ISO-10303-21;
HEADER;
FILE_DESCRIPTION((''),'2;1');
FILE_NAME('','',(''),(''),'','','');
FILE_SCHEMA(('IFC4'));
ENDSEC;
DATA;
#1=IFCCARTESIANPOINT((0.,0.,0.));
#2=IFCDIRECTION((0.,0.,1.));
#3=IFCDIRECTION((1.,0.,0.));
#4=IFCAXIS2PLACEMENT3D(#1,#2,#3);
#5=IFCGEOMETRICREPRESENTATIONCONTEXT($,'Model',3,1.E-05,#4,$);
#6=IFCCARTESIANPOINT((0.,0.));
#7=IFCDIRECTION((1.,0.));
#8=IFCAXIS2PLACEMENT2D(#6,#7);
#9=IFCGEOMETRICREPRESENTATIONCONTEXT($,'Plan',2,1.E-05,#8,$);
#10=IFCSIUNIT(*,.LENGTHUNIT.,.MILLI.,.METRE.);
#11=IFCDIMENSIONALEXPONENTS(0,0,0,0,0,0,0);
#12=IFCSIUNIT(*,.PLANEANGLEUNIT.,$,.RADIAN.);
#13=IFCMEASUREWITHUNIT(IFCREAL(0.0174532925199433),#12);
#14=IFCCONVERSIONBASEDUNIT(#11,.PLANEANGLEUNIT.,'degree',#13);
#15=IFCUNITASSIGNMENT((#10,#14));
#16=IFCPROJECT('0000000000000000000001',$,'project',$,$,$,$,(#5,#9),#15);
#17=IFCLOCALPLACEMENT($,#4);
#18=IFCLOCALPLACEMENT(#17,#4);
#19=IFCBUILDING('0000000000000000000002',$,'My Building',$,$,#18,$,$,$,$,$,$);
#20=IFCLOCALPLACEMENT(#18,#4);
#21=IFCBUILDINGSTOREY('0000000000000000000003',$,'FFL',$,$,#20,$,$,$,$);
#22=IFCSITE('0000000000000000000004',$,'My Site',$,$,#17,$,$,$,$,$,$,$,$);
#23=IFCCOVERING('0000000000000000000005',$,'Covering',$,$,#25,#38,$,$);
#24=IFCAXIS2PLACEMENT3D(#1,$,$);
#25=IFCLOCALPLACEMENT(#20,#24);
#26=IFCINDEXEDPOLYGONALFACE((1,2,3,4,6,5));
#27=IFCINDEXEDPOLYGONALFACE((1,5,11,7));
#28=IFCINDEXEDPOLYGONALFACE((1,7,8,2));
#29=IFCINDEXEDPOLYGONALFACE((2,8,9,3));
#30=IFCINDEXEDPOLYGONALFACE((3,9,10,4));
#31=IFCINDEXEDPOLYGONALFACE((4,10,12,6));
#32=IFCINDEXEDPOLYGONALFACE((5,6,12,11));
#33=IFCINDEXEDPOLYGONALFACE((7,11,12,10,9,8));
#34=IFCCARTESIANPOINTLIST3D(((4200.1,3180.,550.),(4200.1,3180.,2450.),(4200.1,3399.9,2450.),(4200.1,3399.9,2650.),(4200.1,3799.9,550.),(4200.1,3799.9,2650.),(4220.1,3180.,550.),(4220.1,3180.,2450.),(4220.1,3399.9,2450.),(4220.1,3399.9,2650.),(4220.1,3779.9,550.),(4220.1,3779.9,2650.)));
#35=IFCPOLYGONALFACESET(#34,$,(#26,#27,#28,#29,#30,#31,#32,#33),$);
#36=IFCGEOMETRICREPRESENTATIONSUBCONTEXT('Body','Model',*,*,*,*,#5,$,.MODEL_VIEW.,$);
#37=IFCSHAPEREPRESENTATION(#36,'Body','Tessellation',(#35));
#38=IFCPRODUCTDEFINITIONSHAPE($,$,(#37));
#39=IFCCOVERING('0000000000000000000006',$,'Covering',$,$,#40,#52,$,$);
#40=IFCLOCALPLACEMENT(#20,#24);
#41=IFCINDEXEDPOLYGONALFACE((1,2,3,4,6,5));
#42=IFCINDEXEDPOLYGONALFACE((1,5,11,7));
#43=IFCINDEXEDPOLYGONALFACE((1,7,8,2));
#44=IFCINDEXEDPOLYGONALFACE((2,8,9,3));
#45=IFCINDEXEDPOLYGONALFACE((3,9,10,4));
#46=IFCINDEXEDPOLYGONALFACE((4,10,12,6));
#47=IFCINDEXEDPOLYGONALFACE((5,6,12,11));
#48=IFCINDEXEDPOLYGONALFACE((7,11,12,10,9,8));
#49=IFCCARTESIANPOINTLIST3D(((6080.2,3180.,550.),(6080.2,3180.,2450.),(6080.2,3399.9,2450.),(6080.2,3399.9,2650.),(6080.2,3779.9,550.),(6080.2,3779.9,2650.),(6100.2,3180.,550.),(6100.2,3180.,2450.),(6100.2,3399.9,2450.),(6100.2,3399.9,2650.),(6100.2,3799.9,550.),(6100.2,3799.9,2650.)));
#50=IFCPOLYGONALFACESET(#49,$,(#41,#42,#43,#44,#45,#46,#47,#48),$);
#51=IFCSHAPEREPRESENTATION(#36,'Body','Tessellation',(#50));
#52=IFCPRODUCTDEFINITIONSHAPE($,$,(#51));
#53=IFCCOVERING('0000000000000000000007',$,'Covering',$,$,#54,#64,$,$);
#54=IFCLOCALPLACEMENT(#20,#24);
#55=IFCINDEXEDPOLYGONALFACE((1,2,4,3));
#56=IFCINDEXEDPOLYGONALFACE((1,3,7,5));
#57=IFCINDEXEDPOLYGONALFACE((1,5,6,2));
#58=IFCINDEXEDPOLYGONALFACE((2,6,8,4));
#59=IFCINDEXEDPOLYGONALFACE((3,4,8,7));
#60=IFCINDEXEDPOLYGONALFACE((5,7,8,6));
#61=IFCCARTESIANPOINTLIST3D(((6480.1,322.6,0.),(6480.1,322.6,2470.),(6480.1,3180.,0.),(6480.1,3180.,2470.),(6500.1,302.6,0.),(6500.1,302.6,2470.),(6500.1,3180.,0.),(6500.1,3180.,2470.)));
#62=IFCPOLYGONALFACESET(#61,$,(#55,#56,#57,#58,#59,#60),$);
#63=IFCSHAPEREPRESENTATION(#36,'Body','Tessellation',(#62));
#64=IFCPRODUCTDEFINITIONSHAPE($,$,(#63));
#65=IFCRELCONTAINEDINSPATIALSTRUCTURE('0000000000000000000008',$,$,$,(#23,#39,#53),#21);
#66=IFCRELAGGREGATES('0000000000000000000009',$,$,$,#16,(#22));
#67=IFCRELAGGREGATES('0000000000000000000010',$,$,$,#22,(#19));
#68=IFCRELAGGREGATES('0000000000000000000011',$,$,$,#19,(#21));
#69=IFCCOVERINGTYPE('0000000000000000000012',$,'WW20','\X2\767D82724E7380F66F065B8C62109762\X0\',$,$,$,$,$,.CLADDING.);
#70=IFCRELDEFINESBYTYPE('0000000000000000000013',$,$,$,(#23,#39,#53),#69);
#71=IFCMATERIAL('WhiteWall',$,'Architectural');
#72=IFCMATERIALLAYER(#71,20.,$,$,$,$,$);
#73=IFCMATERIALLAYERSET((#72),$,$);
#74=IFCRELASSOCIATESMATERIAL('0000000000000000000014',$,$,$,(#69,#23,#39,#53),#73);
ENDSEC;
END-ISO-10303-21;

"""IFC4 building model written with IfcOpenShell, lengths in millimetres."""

from ifc_helpers import new_model, entity, si_unit, converted_unit, frame, origin_with_axes, origin_2d_with_axis, place, context, subcontext, project, spatial, line, indexed_curve, outline, extrude, material, layer, layer_set, layer_usage, type_object, element, save


model = new_model("IFC4")

# Units and contexts
model_context = context("Model", 3, precision=1e-05, world=origin_with_axes())
plan_context = context("Plan", 2, precision=1e-05, world=origin_2d_with_axis())
body_context_1 = subcontext(model_context, "Body", "Model", "MODEL_VIEW")
ifc_project = project(units=[si_unit("LENGTHUNIT", "METRE", prefix="MILLI"), converted_unit("PLANEANGLEUNIT", "degree", entity("IfcReal", 0.0174532925199433), si_unit("PLANEANGLEUNIT", "RADIAN"), dimensions=[0, 0, 0, 0, 0, 0, 0])], contexts=[model_context, plan_context])

# Site, building, storey
site_placement = place(None, origin_with_axes())
site = spatial("IfcSite", under=ifc_project, at=site_placement, Name="My Site")
building_placement = place(site_placement, origin_with_axes())
building = spatial("IfcBuilding", under=site, at=building_placement, Name="My Building")
storey_placement = place(building_placement, origin_with_axes())
storey = spatial("IfcBuildingStorey", under=building, at=storey_placement, Name="FFL")

# Coverings, openings
ifc_material_1 = material(Name="WhiteWall", Category="Architectural")
ifc_layer_1 = layer(ifc_material_1, 20.0)
ifc_layer_set_1 = layer_set([ifc_layer_1])
ifc_layer_usage_1 = layer_usage(ifc_layer_set_1, "AXIS2", "POSITIVE", 0.0)
covering_type = type_object("IfcCoveringType", Name="WW20", Description="白色乳胶漆完成面", PredefinedType="CLADDING", material=ifc_layer_set_1)
covering_1_placement = place(storey_placement, frame((4200.1, 3799.9, 550.0), z_axis=(0.0, 0.0, 1.0), x_axis=(-0.000001, -1.0, 0.0)))
covering_1 = element("IfcCovering", 1, at=covering_1_placement, inside=storey, type_object=covering_type, material=ifc_layer_usage_1, Name="Covering", context=body_context_1, shape_type="SweptSolid", body=[
    extrude(outline(indexed_curve([(0.0, 0.0), (20.0, 20.0), (620.0, 20.0), (620.0, 0.0)], segments=[line(1, 2, 3, 4, 1)])), origin_with_axes(), (0.0, 0.0, 1.0), 2100.0),
])
opening_1_placement = place(covering_1_placement, frame((620.0, 120.0, 1900.0), z_axis=(0.000001, -1.0, 0.0), x_axis=(0.0, 0.0, 1.0)))
element("IfcOpeningElement", 2, at=opening_1_placement, cuts=covering_1, PredefinedType="OPENING", context=body_context_1, shape_type="SweptSolid", body=[
    extrude(outline(indexed_curve([(0.0, 220.0), (500.0, 220.0), (500.0, -100.0), (0.0, -100.0), (0.0, 220.0)])), origin_with_axes(), (0.0, 0.0, 1.0), 500.0),
])
ifc_layer_usage_2 = layer_usage(ifc_layer_set_1, "AXIS2", "NEGATIVE", 0.0)
covering_2_placement = place(storey_placement, frame((6100.2, 3799.9, 550.0), z_axis=(0.0, 0.0, 1.0), x_axis=(-0.000001, -1.0, 0.0)))
covering_2 = element("IfcCovering", 3, at=covering_2_placement, inside=storey, type_object=covering_type, material=ifc_layer_usage_2, Name="Covering", context=body_context_1, shape_type="SweptSolid", body=[
    extrude(outline(indexed_curve([(20.0, -20.0), (0.0, 0.0), (620.0, 0.0), (620.0, -20.0)], segments=[line(1, 2, 3, 4, 1)])), origin_with_axes(), (0.0, 0.0, 1.0), 2100.0),
])
opening_2_placement = place(covering_2_placement, frame((620.0, 120.0, 1900.0), z_axis=(0.000001, -1.0, 0.0), x_axis=(0.0, 0.0, 1.0)))
element("IfcOpeningElement", 4, at=opening_2_placement, cuts=covering_2, PredefinedType="OPENING", context=body_context_1, shape_type="SweptSolid", body=[
    extrude(outline(indexed_curve([(0.0, 220.0), (500.0, 220.0), (500.0, -100.0), (0.0, -100.0), (0.0, 220.0)])), origin_with_axes(), (0.0, 0.0, 1.0), 500.0),
])

# Covering
ifc_layer_usage_3 = layer_usage(ifc_layer_set_1, "AXIS2", "NEGATIVE", 0.0)
covering_3_placement = place(storey_placement, frame((6500.1, 3200.0, 0.0), z_axis=(0.0, 0.0, 1.0), x_axis=(-0.000001, -1.0, 0.0)))
element("IfcCovering", 5, at=covering_3_placement, inside=storey, type_object=covering_type, material=ifc_layer_usage_3, Name="Covering", context=body_context_1, shape_type="SweptSolid", body=[
    extrude(outline(indexed_curve([(20.0, -20.0), (20.0, 0.0), (2897.4, 0.0), (2877.4, -20.0)], segments=[line(1, 2, 3, 4, 1)])), origin_with_axes(), (0.0, 0.0, 1.0), 2470.0),
])

save(model, "model.ifc")
